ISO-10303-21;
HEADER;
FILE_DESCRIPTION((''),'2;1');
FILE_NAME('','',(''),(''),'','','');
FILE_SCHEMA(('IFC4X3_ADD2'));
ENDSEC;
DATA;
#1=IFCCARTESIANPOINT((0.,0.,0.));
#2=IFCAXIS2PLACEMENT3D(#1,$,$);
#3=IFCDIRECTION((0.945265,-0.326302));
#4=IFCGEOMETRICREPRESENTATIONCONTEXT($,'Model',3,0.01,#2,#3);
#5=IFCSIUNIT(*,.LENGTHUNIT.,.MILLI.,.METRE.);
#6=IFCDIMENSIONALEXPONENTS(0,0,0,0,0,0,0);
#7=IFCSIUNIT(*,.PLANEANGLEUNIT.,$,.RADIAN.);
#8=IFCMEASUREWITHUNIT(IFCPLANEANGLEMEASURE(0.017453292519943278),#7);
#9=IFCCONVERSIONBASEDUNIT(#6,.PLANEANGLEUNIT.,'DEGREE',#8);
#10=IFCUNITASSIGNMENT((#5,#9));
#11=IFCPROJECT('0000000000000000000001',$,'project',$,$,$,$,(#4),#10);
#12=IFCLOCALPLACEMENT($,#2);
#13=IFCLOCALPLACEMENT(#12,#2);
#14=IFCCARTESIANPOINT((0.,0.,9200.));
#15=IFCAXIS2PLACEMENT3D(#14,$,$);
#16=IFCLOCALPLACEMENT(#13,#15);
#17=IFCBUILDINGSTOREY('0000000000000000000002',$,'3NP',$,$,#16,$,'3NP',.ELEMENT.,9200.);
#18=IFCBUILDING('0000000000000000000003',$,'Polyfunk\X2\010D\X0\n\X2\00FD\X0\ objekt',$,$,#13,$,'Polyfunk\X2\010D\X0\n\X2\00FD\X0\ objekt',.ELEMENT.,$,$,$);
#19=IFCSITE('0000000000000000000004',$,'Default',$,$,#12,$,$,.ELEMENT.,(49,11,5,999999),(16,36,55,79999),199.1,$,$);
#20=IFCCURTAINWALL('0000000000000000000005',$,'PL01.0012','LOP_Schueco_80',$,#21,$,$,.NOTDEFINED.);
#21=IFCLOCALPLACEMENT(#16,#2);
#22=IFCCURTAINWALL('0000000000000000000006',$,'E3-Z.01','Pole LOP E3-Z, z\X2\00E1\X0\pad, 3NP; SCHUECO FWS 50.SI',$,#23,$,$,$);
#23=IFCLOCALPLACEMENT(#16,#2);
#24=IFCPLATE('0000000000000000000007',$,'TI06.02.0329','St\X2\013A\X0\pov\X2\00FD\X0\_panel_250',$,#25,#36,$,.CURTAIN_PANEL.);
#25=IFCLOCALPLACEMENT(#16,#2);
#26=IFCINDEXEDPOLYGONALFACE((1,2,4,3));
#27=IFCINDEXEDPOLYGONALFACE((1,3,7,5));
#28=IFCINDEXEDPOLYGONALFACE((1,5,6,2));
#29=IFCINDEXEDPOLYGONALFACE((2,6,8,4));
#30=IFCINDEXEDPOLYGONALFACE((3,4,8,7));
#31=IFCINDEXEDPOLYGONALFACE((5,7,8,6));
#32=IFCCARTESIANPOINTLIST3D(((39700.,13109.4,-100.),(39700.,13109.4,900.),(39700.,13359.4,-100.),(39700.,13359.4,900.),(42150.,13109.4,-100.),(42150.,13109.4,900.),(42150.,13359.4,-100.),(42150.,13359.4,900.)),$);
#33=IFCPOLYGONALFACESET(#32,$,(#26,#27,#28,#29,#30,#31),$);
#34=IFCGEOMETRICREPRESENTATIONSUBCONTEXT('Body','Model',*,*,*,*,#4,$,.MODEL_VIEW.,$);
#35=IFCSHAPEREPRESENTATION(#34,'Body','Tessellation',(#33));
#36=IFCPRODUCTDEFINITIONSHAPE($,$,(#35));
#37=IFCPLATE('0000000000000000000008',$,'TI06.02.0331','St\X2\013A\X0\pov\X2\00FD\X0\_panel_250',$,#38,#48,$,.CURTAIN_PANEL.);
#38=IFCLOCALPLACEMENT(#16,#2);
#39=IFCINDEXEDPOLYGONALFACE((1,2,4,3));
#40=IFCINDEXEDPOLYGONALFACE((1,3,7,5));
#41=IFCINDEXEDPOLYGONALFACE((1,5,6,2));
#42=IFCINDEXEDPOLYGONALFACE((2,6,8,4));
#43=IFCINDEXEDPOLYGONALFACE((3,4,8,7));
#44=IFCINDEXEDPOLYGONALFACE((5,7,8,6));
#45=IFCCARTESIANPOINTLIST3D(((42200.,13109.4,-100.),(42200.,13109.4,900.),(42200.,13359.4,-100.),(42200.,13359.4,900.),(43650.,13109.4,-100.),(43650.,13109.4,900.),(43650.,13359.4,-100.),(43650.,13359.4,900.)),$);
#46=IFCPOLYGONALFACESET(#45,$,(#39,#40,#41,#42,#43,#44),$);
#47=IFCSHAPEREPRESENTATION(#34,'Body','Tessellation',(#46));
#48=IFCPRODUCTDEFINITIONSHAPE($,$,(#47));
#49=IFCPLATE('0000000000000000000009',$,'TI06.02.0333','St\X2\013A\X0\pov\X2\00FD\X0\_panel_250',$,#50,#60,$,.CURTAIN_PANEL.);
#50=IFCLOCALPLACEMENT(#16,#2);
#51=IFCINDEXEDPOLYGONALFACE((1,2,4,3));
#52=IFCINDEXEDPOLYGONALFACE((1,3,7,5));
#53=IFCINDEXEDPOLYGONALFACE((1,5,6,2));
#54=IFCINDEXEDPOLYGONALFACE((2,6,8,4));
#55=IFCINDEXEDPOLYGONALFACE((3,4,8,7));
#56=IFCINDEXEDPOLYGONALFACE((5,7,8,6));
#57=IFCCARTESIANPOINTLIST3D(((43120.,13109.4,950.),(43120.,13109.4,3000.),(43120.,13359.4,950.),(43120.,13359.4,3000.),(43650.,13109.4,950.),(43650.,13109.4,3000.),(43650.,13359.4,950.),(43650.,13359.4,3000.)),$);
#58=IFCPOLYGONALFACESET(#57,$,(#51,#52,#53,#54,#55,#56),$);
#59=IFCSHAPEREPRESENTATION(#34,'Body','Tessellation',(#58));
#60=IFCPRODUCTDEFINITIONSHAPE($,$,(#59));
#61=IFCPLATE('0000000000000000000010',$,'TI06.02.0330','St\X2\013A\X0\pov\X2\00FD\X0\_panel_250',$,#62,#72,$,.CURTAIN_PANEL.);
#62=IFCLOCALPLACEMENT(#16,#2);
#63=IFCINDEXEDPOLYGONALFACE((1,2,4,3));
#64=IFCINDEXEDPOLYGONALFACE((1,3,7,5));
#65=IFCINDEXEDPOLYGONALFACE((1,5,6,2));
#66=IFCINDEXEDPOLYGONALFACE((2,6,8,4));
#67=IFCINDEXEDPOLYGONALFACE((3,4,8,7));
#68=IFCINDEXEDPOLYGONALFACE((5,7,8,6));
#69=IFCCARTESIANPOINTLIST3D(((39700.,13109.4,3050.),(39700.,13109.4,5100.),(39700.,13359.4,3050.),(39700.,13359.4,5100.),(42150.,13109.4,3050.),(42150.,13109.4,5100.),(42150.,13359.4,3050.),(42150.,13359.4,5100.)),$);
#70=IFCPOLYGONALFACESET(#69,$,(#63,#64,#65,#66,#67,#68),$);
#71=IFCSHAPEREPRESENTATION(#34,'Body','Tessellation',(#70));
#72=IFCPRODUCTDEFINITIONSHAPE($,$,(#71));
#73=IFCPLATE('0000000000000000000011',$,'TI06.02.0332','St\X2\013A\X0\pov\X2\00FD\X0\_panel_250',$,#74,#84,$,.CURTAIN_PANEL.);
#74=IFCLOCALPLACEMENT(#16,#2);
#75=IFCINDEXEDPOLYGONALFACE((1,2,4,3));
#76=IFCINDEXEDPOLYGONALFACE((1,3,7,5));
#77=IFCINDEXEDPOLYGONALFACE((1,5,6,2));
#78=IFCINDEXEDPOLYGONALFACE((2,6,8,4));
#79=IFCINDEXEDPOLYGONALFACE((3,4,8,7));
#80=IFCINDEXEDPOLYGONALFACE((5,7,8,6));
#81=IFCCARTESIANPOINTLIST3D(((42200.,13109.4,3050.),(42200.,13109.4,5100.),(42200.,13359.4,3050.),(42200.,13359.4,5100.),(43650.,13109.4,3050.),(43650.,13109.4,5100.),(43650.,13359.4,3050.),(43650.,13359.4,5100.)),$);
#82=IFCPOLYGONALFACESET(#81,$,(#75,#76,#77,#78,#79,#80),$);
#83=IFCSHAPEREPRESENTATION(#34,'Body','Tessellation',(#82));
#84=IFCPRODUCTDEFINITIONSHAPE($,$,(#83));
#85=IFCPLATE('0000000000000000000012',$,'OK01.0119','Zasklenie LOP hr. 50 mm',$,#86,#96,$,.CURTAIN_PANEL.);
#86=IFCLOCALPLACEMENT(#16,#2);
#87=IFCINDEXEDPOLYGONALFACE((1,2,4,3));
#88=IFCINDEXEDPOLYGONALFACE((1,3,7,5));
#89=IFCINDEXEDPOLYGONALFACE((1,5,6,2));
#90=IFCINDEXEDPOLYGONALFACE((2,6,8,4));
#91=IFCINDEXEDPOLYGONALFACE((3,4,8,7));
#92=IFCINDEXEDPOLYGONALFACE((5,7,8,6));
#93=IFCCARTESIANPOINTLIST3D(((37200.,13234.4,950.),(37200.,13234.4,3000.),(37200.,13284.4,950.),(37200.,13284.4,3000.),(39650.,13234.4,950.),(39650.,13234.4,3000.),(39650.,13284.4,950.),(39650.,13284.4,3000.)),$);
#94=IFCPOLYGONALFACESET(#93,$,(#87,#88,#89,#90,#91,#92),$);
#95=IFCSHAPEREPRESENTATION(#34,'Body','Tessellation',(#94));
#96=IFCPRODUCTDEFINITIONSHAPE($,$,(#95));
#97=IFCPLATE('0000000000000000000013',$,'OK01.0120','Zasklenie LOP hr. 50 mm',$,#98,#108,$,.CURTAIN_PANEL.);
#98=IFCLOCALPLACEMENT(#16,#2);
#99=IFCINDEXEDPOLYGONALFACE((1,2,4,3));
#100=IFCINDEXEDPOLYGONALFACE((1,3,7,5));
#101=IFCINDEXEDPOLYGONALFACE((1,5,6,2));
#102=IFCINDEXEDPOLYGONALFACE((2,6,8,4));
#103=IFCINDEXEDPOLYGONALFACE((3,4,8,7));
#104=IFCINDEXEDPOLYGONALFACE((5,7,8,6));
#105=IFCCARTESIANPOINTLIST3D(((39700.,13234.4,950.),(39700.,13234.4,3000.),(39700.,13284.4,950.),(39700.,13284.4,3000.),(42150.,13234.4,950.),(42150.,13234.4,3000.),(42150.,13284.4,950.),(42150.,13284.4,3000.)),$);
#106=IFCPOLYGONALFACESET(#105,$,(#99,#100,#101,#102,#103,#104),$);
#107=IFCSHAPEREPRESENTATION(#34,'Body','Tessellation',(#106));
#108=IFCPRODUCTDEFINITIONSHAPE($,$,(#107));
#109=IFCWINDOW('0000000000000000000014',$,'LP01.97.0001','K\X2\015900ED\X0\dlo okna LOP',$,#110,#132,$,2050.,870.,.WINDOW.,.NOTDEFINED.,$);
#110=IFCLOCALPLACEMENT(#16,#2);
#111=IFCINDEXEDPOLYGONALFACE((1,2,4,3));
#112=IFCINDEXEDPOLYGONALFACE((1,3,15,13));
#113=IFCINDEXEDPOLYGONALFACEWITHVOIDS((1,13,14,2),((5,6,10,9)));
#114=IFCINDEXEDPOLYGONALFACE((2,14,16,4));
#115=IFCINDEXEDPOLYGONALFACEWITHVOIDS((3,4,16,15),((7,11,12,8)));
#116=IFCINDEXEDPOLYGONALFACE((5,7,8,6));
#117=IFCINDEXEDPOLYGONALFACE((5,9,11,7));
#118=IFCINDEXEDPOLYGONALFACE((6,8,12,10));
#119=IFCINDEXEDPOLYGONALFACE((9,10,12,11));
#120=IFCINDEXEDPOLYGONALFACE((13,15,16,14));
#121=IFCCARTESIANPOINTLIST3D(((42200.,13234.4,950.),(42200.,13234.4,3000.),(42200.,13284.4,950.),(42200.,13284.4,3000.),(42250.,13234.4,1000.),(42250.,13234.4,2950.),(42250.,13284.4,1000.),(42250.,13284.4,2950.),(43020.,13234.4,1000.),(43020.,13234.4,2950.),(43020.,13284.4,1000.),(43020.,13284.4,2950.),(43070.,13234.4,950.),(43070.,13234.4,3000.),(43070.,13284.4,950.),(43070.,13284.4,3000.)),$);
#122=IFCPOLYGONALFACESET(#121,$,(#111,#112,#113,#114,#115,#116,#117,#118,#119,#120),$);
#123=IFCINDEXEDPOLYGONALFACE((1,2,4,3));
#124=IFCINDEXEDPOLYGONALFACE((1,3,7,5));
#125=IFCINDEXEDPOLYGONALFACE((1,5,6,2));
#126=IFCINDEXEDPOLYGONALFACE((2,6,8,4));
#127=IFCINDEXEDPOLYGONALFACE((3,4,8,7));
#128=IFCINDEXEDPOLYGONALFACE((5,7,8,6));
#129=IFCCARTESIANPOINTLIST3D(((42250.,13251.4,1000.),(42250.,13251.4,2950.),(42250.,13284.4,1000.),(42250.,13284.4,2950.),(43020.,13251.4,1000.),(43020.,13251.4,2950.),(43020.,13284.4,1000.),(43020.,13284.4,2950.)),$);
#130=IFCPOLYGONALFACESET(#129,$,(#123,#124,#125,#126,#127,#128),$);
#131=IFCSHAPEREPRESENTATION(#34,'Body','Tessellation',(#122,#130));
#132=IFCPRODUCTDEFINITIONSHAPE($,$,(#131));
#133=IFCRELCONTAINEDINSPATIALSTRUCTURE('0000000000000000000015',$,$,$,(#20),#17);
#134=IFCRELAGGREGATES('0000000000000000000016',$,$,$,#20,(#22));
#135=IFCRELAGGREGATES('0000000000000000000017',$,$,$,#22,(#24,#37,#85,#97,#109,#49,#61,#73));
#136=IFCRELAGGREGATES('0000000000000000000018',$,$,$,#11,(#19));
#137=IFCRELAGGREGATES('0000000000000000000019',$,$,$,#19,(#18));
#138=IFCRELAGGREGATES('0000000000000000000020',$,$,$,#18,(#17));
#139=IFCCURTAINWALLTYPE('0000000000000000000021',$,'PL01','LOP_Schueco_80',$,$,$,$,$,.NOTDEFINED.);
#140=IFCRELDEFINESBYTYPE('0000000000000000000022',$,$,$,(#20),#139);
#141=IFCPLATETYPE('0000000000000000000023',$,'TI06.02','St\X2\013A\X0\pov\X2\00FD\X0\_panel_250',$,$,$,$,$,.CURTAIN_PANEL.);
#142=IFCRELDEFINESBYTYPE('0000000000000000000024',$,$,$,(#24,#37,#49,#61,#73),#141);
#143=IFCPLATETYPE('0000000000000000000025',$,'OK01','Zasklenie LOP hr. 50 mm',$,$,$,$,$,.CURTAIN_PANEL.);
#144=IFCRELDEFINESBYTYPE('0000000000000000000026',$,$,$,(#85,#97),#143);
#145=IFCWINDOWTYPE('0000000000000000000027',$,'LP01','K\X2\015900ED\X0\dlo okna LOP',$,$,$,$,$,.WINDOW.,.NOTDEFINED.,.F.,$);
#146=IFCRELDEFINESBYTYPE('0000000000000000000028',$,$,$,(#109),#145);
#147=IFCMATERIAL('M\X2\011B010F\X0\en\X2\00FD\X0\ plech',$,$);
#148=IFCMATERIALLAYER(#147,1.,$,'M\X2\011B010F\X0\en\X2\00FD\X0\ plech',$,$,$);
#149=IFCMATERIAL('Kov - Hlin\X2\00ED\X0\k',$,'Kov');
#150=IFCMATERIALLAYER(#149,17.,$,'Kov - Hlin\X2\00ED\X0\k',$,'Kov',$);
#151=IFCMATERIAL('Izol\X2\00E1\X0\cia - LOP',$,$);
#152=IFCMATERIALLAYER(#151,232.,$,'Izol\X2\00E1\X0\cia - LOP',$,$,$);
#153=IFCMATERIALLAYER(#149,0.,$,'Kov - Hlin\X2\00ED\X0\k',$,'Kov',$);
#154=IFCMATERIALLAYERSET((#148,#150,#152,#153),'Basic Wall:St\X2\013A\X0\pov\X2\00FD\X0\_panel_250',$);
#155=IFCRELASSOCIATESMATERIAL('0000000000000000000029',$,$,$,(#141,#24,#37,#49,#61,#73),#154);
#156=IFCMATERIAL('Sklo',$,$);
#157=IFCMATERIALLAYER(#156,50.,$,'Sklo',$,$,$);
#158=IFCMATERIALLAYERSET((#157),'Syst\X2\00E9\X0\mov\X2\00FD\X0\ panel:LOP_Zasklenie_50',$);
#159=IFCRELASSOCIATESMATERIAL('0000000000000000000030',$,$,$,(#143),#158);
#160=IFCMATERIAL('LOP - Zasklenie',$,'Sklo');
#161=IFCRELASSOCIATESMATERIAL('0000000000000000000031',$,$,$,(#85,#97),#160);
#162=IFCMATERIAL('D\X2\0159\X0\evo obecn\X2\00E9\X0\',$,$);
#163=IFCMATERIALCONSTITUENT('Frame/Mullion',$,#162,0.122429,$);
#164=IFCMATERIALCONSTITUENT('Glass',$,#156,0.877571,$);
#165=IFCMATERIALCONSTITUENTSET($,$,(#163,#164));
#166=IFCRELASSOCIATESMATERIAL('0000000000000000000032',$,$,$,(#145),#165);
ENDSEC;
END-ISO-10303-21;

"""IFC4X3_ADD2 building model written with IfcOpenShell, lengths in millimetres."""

from ifc_helpers import new_model, entity, si_unit, converted_unit, direction, frame, frame_2d, origin, origin_2d_with_axis, place, context, subcontext, project, spatial, polyline, rectangle, outline, extrude, source, transform, mapped, material, layer, layer_set, layer_usage, constituent, constituent_set, type_object, type_shapes, element, aggregate, save


model = new_model("IFC4X3_ADD2")

# Units and contexts
model_context = context("Model", 3, precision=0.01, world=origin(), true_north=direction((0.945265, -0.326302)))
body_context = subcontext(model_context, "Body", "Model", "MODEL_VIEW")
ifc_project = project(units=[si_unit("LENGTHUNIT", "METRE", prefix="MILLI"), converted_unit("PLANEANGLEUNIT", "DEGREE", entity("IfcPlaneAngleMeasure", 0.017453292519943278), si_unit("PLANEANGLEUNIT", "RADIAN"), dimensions=[0, 0, 0, 0, 0, 0, 0])], contexts=[model_context])

# Site, building, storey
site_placement = place(None, origin())
site = spatial("IfcSite", under=ifc_project, at=site_placement, Name="Default", CompositionType="ELEMENT", RefLatitude=(49, 11, 5, 999999), RefLongitude=(16, 36, 55, 79999), RefElevation=199.1)
building_placement = place(site_placement, origin())
building = spatial("IfcBuilding", under=site, at=building_placement, Name="Polyfunkčný objekt", LongName="Polyfunkčný objekt", CompositionType="ELEMENT")
storey_placement = place(building_placement, frame((0.0, 0.0, 9200.0)))
storey = spatial("IfcBuildingStorey", under=building, at=storey_placement, Name="3NP", LongName="3NP", CompositionType="ELEMENT", Elevation=9200.0)

# Curtain walls, plates, window
curtain_wall_type = type_object("IfcCurtainWallType", Name="PL01", Description="LOP_Schueco_80", PredefinedType="NOTDEFINED")
curtain_wall_1_placement = place(storey_placement, frame((0.0, 0.0, -9200.0)))
curtain_wall_1 = element("IfcCurtainWall", 1, at=curtain_wall_1_placement, inside=storey, type_object=curtain_wall_type, Name="PL01.0012", Description="LOP_Schueco_80", PredefinedType="NOTDEFINED")
curtain_wall_2 = element("IfcCurtainWall", 2, Name="E3-Z.01", Description="Pole LOP E3-Z, západ, 3NP; SCHUECO FWS 50.SI")
aggregate(curtain_wall_1, [curtain_wall_2])
ifc_material_1 = material(Name="Měďený plech")
ifc_layer_1 = layer(ifc_material_1, 1.0, Name="Měďený plech")
ifc_material_2 = material(Name="Kov - Hliník", Category="Kov")
ifc_layer_2 = layer(ifc_material_2, 17.0, Name="Kov - Hliník", Category="Kov")
ifc_material_3 = material(Name="Izolácia - LOP")
ifc_layer_3 = layer(ifc_material_3, 232.0, Name="Izolácia - LOP")
ifc_layer_4 = layer(ifc_material_2, 0.0, Name="Kov - Hliník", Category="Kov")
ifc_layer_set_1 = layer_set([ifc_layer_1, ifc_layer_2, ifc_layer_3, ifc_layer_4], Name="Basic Wall:Stĺpový_panel_250")
ifc_layer_usage_1 = layer_usage(ifc_layer_set_1, "AXIS2", "NEGATIVE", 125.0)
plate_type_1 = type_object("IfcPlateType", Name="TI06.02", Description="Stĺpový_panel_250", PredefinedType="CURTAIN_PANEL", material=ifc_layer_set_1)
plate_1_placement = place(storey_placement, frame((39700.0, 13234.4, -100.0)))
plate_1 = element("IfcPlate", 3, at=plate_1_placement, type_object=plate_type_1, material=ifc_layer_usage_1, Name="TI06.02.0329", Description="Stĺpový_panel_250", PredefinedType="CURTAIN_PANEL", context=body_context, shape_type="SweptSolid", body=[
    extrude(rectangle(XDim=250.0, YDim=2450.0, at=frame_2d((0.0, 0.0), x_axis=(1.0, 0.0))), frame((1225.0, 0.0, 0.0), z_axis=(0.0, 0.0, 1.0), x_axis=(0.0, 1.0, 0.0)), (0.0, 0.0, 1.0), 1000.0),
])
ifc_layer_usage_2 = layer_usage(ifc_layer_set_1, "AXIS2", "NEGATIVE", 125.0)
plate_2_placement = place(storey_placement, frame((42200.0, 13234.4, -100.0)))
plate_2 = element("IfcPlate", 4, at=plate_2_placement, type_object=plate_type_1, material=ifc_layer_usage_2, Name="TI06.02.0331", Description="Stĺpový_panel_250", PredefinedType="CURTAIN_PANEL", context=body_context, shape_type="SweptSolid", body=[
    extrude(rectangle(XDim=250.0, YDim=1450.0, at=frame_2d((0.0, 0.0), x_axis=(1.0, 0.0))), frame((725.0, 0.0, 0.0), z_axis=(0.0, 0.0, 1.0), x_axis=(0.0, 1.0, 0.0)), (0.0, 0.0, 1.0), 1000.0),
])
ifc_layer_usage_3 = layer_usage(ifc_layer_set_1, "AXIS2", "NEGATIVE", 125.0)
plate_3_placement = place(storey_placement, frame((43120.0, 13234.4, 950.0)))
plate_3 = element("IfcPlate", 5, at=plate_3_placement, type_object=plate_type_1, material=ifc_layer_usage_3, Name="TI06.02.0333", Description="Stĺpový_panel_250", PredefinedType="CURTAIN_PANEL", context=body_context, shape_type="SweptSolid", body=[
    extrude(rectangle(XDim=250.0, YDim=530.0, at=frame_2d((0.0, 0.0), x_axis=(1.0, 0.0))), frame((265.0, 0.0, 0.0), z_axis=(0.0, 0.0, 1.0), x_axis=(0.0, 1.0, 0.0)), (0.0, 0.0, 1.0), 2050.0),
])
ifc_layer_usage_4 = layer_usage(ifc_layer_set_1, "AXIS2", "NEGATIVE", 125.0)
plate_4_placement = place(storey_placement, frame((39700.0, 13234.4, 3050.0)))
plate_4 = element("IfcPlate", 6, at=plate_4_placement, type_object=plate_type_1, material=ifc_layer_usage_4, Name="TI06.02.0330", Description="Stĺpový_panel_250", PredefinedType="CURTAIN_PANEL", context=body_context, shape_type="SweptSolid", body=[
    extrude(rectangle(XDim=250.0, YDim=2450.0, at=frame_2d((0.0, 0.0), x_axis=(1.0, 0.0))), frame((1225.0, 0.0, 0.0), z_axis=(0.0, 0.0, 1.0), x_axis=(0.0, 1.0, 0.0)), (0.0, 0.0, 1.0), 2050.0),
])
ifc_layer_usage_5 = layer_usage(ifc_layer_set_1, "AXIS2", "NEGATIVE", 125.0)
plate_5_placement = place(storey_placement, frame((42200.0, 13234.4, 3050.0)))
plate_5 = element("IfcPlate", 7, at=plate_5_placement, type_object=plate_type_1, material=ifc_layer_usage_5, Name="TI06.02.0332", Description="Stĺpový_panel_250", PredefinedType="CURTAIN_PANEL", context=body_context, shape_type="SweptSolid", body=[
    extrude(rectangle(XDim=250.0, YDim=1450.0, at=frame_2d((0.0, 0.0), x_axis=(1.0, 0.0))), frame((725.0, 0.0, 0.0), z_axis=(0.0, 0.0, 1.0), x_axis=(0.0, 1.0, 0.0)), (0.0, 0.0, 1.0), 2050.0),
])
ifc_material_4 = material(Name="LOP - Zasklenie", Category="Sklo")
ifc_material_5 = material(Name="Sklo")
ifc_layer_5 = layer(ifc_material_5, 50.0, Name="Sklo")
ifc_layer_set_2 = layer_set([ifc_layer_5], Name="Systémový panel:LOP_Zasklenie_50")
plate_type_2 = type_object("IfcPlateType", Name="OK01", Description="Zasklenie LOP hr. 50 mm", PredefinedType="CURTAIN_PANEL", material=ifc_layer_set_2)
shared_shape_1 = source(origin(), body_context, "Body", "SweptSolid", [
    extrude(rectangle(XDim=50.0, YDim=2450.0, at=origin_2d_with_axis()), frame((0.0, 25.0, 0.0), z_axis=(0.0, 0.0, 1.0), x_axis=(0.0, 1.0, 0.0)), (0.0, 0.0, 1.0), 2050.0),
])
type_shapes(plate_type_2, [shared_shape_1])
plate_6_placement = place(curtain_wall_1_placement, frame((38425.0, 13234.4, 10150.0)))
plate_6 = element("IfcPlate", 8, at=plate_6_placement, type_object=plate_type_2, material=ifc_material_4, Name="OK01.0119", Description="Zasklenie LOP hr. 50 mm", PredefinedType="CURTAIN_PANEL", context=body_context, shape_type="MappedRepresentation", body=[
    mapped(shared_shape_1, transform((0.0, 0.0, 0.0), scale=1.0)),
])
plate_7_placement = place(curtain_wall_1_placement, frame((40925.0, 13234.4, 10150.0)))
plate_7 = element("IfcPlate", 9, at=plate_7_placement, type_object=plate_type_2, material=ifc_material_4, Name="OK01.0120", Description="Zasklenie LOP hr. 50 mm", PredefinedType="CURTAIN_PANEL", context=body_context, shape_type="MappedRepresentation", body=[
    mapped(shared_shape_1, transform((0.0, 0.0, 0.0), scale=1.0)),
])
ifc_material_6 = material(Name="Dřevo obecné")
ifc_constituent_1 = constituent(ifc_material_6, Name="Frame/Mullion", fraction=0.122429)
ifc_constituent_2 = constituent(ifc_material_5, Name="Glass", fraction=0.877571)
ifc_constituent_set = constituent_set(constituents=[ifc_constituent_1, ifc_constituent_2])
window_type = type_object("IfcWindowType", Name="LP01", Description="Křídlo okna LOP", ParameterTakesPrecedence=False, PartitioningType="NOTDEFINED", PredefinedType="WINDOW", material=ifc_constituent_set)
shared_shape_2 = source(origin(), body_context, "Body", "SweptSolid", [
    extrude(outline(polyline([(-1025.0, -435.0), (1025.0, -435.0), (1025.0, 435.0), (-1025.0, 435.0), (-1025.0, -435.0)]), holes=[polyline([(-975.0, -385.0), (-975.0, 385.0), (975.0, 385.0), (975.0, -385.0), (-975.0, -385.0)])]), frame((0.0, 0.0, 1025.0), z_axis=(0.0, 1.0, 0.0), x_axis=(0.0, 0.0, -1.0)), (0.0, 0.0, 1.0), 50.0),
    extrude(rectangle(XDim=33.0, YDim=770.0, at=origin_2d_with_axis()), frame((0.0, 33.5, 50.0), z_axis=(0.0, 0.0, 1.0), x_axis=(0.0, -1.0, 0.0)), (0.0, 0.0, 1.0), 1950.0),
])
type_shapes(window_type, [shared_shape_2])
window_placement = place(curtain_wall_1_placement, frame((42635.0, 13234.4, 10150.0)))
window = element("IfcWindow", 10, at=window_placement, type_object=window_type, Name="LP01.97.0001", Description="Křídlo okna LOP", OverallHeight=2050.0, OverallWidth=870.0, PartitioningType="NOTDEFINED", PredefinedType="WINDOW", context=body_context, shape_type="MappedRepresentation", body=[
    mapped(shared_shape_2, transform((0.0, 0.0, 0.0), scale=1.0)),
])
aggregate(curtain_wall_2, [plate_1, plate_2, plate_6, plate_7, window, plate_3, plate_4, plate_5])

save(model, "model.ifc")
